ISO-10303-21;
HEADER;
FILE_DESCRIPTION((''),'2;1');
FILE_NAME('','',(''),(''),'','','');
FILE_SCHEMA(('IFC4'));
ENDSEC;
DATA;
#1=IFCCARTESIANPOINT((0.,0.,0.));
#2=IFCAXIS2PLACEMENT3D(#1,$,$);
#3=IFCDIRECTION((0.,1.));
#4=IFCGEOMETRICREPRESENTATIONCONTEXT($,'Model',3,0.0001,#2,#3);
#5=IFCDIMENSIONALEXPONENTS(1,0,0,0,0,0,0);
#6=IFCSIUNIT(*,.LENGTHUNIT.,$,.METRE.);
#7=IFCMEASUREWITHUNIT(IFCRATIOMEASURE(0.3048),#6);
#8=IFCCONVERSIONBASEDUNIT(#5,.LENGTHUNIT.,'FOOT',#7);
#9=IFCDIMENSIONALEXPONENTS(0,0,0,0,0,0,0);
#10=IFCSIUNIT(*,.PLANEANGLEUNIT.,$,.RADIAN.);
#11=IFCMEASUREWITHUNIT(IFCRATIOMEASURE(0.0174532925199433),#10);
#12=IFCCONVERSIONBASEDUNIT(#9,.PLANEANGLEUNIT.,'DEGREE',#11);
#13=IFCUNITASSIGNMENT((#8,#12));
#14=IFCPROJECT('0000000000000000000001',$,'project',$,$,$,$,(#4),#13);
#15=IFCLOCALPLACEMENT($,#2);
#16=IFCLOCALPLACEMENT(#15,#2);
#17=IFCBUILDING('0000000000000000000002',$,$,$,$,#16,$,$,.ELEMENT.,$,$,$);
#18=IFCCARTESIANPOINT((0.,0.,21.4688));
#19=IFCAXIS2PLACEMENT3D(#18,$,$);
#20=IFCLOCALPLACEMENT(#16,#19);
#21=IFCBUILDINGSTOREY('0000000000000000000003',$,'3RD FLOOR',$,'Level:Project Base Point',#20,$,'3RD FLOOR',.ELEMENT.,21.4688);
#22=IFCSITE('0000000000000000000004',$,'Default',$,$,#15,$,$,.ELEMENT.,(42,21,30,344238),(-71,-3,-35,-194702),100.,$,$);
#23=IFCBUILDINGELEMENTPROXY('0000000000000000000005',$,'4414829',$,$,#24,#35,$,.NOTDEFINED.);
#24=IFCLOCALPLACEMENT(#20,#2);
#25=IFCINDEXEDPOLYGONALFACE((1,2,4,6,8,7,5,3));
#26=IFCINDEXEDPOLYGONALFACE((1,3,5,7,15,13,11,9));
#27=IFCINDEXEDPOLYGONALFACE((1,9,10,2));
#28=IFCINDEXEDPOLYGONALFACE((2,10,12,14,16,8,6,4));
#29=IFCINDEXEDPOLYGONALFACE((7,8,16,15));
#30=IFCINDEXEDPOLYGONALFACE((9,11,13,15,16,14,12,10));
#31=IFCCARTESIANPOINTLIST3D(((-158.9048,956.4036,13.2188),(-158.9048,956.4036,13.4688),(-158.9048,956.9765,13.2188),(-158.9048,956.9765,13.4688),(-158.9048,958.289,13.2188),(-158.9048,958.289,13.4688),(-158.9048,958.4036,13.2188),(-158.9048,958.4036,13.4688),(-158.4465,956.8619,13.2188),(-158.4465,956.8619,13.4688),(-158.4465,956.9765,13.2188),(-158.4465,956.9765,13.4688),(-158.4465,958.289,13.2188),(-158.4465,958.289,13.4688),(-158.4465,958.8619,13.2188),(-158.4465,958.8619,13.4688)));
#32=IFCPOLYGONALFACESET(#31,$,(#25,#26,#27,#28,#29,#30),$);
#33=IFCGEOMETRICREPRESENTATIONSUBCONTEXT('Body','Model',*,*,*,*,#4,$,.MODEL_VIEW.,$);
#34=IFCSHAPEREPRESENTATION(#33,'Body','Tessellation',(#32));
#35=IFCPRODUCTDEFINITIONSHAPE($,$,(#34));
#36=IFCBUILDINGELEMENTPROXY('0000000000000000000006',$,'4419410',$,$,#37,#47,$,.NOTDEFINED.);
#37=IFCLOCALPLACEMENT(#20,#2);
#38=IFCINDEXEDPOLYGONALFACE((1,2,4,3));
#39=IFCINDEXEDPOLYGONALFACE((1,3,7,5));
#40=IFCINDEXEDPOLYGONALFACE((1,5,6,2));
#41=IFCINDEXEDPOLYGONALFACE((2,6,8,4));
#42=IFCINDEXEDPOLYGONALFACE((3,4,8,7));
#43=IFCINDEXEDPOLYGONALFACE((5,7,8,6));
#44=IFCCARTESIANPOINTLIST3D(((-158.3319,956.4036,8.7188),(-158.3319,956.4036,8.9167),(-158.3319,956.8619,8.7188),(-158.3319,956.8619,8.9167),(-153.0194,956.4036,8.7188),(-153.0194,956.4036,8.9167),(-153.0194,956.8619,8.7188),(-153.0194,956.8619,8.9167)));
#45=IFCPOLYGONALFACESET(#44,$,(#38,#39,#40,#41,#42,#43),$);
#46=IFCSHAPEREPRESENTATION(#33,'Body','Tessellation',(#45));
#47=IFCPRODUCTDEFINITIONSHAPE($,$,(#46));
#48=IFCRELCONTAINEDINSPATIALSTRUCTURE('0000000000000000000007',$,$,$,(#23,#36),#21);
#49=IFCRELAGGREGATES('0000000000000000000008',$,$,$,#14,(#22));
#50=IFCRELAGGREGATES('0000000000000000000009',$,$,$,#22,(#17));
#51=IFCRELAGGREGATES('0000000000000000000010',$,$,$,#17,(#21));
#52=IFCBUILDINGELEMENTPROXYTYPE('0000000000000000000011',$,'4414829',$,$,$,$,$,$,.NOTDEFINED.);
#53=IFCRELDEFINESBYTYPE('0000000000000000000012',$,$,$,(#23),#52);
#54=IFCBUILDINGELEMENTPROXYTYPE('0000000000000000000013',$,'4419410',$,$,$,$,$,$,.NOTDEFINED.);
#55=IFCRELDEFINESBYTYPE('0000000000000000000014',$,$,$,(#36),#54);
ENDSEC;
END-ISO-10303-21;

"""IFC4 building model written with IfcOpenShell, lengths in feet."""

from ifc_helpers import new_model, entity, si_unit, converted_unit, direction, frame, origin, origin_2d_with_axis, place, context, subcontext, project, spatial, polyline, rectangle, outline, extrude, type_object, element, save


model = new_model("IFC4")

# Units and contexts
model_context = context("Model", 3, precision=0.0001, world=origin(), true_north=direction((0.0, 1.0)))
body_context = subcontext(model_context, "Body", "Model", "MODEL_VIEW")
ifc_project = project(units=[converted_unit("LENGTHUNIT", "FOOT", entity("IfcRatioMeasure", 0.3048), si_unit("LENGTHUNIT", "METRE"), dimensions=[1, 0, 0, 0, 0, 0, 0]), converted_unit("PLANEANGLEUNIT", "DEGREE", entity("IfcRatioMeasure", 0.0174532925199433), si_unit("PLANEANGLEUNIT", "RADIAN"), dimensions=[0, 0, 0, 0, 0, 0, 0])], contexts=[model_context])

# Site, building, storey
site_placement = place(None, origin())
site = spatial("IfcSite", under=ifc_project, at=site_placement, Name="Default", CompositionType="ELEMENT", RefLatitude=(42, 21, 30, 344238), RefLongitude=(-71, -3, -35, -194702), RefElevation=100.0)
building_placement = place(site_placement, origin())
building = spatial("IfcBuilding", under=site, at=building_placement, CompositionType="ELEMENT")
storey_placement = place(building_placement, frame((0.0, 0.0, 21.4688)))
storey = spatial("IfcBuildingStorey", under=building, at=storey_placement, Name="3RD FLOOR", ObjectType="Level:Project Base Point", LongName="3RD FLOOR", CompositionType="ELEMENT", Elevation=21.4688)

# Building element proxies
building_element_proxy_type_1 = type_object("IfcBuildingElementProxyType", Name="4414829", PredefinedType="NOTDEFINED")
proxy_1_placement = place(storey_placement, frame((-158.9048, 956.4036, 13.2188)))
element("IfcBuildingElementProxy", 1, at=proxy_1_placement, inside=storey, type_object=building_element_proxy_type_1, Name="4414829", PredefinedType="NOTDEFINED", context=body_context, shape_type="SweptSolid", body=[
    extrude(outline(polyline([(-0.7708, -0.2292), (-0.6563, -0.2292), (0.6563, -0.2292), (1.2292, -0.2292), (0.7708, 0.2292), (0.6563, 0.2292), (-0.6563, 0.2292), (-1.2292, 0.2292), (-0.7708, -0.2292)])), frame((0.2292, 1.2292, 0.0), z_axis=(0.0, 0.0, 1.0), x_axis=(0.0, 1.0, 0.0)), (0.0, 0.0, 1.0), 0.25),
])
building_element_proxy_type_2 = type_object("IfcBuildingElementProxyType", Name="4419410", PredefinedType="NOTDEFINED")
proxy_2_placement = place(storey_placement, frame((-158.3319, 956.4036, 8.7188)))
element("IfcBuildingElementProxy", 2, at=proxy_2_placement, inside=storey, type_object=building_element_proxy_type_2, Name="4419410", PredefinedType="NOTDEFINED", context=body_context, shape_type="SweptSolid", body=[
    extrude(rectangle(XDim=5.3125, YDim=0.4583, at=origin_2d_with_axis()), frame((2.6562, 0.2292, 0.0), z_axis=(0.0, 0.0, 1.0), x_axis=(-1.0, 0.0, 0.0)), (0.0, 0.0, 1.0), 0.1979),
])

save(model, "model.ifc")
